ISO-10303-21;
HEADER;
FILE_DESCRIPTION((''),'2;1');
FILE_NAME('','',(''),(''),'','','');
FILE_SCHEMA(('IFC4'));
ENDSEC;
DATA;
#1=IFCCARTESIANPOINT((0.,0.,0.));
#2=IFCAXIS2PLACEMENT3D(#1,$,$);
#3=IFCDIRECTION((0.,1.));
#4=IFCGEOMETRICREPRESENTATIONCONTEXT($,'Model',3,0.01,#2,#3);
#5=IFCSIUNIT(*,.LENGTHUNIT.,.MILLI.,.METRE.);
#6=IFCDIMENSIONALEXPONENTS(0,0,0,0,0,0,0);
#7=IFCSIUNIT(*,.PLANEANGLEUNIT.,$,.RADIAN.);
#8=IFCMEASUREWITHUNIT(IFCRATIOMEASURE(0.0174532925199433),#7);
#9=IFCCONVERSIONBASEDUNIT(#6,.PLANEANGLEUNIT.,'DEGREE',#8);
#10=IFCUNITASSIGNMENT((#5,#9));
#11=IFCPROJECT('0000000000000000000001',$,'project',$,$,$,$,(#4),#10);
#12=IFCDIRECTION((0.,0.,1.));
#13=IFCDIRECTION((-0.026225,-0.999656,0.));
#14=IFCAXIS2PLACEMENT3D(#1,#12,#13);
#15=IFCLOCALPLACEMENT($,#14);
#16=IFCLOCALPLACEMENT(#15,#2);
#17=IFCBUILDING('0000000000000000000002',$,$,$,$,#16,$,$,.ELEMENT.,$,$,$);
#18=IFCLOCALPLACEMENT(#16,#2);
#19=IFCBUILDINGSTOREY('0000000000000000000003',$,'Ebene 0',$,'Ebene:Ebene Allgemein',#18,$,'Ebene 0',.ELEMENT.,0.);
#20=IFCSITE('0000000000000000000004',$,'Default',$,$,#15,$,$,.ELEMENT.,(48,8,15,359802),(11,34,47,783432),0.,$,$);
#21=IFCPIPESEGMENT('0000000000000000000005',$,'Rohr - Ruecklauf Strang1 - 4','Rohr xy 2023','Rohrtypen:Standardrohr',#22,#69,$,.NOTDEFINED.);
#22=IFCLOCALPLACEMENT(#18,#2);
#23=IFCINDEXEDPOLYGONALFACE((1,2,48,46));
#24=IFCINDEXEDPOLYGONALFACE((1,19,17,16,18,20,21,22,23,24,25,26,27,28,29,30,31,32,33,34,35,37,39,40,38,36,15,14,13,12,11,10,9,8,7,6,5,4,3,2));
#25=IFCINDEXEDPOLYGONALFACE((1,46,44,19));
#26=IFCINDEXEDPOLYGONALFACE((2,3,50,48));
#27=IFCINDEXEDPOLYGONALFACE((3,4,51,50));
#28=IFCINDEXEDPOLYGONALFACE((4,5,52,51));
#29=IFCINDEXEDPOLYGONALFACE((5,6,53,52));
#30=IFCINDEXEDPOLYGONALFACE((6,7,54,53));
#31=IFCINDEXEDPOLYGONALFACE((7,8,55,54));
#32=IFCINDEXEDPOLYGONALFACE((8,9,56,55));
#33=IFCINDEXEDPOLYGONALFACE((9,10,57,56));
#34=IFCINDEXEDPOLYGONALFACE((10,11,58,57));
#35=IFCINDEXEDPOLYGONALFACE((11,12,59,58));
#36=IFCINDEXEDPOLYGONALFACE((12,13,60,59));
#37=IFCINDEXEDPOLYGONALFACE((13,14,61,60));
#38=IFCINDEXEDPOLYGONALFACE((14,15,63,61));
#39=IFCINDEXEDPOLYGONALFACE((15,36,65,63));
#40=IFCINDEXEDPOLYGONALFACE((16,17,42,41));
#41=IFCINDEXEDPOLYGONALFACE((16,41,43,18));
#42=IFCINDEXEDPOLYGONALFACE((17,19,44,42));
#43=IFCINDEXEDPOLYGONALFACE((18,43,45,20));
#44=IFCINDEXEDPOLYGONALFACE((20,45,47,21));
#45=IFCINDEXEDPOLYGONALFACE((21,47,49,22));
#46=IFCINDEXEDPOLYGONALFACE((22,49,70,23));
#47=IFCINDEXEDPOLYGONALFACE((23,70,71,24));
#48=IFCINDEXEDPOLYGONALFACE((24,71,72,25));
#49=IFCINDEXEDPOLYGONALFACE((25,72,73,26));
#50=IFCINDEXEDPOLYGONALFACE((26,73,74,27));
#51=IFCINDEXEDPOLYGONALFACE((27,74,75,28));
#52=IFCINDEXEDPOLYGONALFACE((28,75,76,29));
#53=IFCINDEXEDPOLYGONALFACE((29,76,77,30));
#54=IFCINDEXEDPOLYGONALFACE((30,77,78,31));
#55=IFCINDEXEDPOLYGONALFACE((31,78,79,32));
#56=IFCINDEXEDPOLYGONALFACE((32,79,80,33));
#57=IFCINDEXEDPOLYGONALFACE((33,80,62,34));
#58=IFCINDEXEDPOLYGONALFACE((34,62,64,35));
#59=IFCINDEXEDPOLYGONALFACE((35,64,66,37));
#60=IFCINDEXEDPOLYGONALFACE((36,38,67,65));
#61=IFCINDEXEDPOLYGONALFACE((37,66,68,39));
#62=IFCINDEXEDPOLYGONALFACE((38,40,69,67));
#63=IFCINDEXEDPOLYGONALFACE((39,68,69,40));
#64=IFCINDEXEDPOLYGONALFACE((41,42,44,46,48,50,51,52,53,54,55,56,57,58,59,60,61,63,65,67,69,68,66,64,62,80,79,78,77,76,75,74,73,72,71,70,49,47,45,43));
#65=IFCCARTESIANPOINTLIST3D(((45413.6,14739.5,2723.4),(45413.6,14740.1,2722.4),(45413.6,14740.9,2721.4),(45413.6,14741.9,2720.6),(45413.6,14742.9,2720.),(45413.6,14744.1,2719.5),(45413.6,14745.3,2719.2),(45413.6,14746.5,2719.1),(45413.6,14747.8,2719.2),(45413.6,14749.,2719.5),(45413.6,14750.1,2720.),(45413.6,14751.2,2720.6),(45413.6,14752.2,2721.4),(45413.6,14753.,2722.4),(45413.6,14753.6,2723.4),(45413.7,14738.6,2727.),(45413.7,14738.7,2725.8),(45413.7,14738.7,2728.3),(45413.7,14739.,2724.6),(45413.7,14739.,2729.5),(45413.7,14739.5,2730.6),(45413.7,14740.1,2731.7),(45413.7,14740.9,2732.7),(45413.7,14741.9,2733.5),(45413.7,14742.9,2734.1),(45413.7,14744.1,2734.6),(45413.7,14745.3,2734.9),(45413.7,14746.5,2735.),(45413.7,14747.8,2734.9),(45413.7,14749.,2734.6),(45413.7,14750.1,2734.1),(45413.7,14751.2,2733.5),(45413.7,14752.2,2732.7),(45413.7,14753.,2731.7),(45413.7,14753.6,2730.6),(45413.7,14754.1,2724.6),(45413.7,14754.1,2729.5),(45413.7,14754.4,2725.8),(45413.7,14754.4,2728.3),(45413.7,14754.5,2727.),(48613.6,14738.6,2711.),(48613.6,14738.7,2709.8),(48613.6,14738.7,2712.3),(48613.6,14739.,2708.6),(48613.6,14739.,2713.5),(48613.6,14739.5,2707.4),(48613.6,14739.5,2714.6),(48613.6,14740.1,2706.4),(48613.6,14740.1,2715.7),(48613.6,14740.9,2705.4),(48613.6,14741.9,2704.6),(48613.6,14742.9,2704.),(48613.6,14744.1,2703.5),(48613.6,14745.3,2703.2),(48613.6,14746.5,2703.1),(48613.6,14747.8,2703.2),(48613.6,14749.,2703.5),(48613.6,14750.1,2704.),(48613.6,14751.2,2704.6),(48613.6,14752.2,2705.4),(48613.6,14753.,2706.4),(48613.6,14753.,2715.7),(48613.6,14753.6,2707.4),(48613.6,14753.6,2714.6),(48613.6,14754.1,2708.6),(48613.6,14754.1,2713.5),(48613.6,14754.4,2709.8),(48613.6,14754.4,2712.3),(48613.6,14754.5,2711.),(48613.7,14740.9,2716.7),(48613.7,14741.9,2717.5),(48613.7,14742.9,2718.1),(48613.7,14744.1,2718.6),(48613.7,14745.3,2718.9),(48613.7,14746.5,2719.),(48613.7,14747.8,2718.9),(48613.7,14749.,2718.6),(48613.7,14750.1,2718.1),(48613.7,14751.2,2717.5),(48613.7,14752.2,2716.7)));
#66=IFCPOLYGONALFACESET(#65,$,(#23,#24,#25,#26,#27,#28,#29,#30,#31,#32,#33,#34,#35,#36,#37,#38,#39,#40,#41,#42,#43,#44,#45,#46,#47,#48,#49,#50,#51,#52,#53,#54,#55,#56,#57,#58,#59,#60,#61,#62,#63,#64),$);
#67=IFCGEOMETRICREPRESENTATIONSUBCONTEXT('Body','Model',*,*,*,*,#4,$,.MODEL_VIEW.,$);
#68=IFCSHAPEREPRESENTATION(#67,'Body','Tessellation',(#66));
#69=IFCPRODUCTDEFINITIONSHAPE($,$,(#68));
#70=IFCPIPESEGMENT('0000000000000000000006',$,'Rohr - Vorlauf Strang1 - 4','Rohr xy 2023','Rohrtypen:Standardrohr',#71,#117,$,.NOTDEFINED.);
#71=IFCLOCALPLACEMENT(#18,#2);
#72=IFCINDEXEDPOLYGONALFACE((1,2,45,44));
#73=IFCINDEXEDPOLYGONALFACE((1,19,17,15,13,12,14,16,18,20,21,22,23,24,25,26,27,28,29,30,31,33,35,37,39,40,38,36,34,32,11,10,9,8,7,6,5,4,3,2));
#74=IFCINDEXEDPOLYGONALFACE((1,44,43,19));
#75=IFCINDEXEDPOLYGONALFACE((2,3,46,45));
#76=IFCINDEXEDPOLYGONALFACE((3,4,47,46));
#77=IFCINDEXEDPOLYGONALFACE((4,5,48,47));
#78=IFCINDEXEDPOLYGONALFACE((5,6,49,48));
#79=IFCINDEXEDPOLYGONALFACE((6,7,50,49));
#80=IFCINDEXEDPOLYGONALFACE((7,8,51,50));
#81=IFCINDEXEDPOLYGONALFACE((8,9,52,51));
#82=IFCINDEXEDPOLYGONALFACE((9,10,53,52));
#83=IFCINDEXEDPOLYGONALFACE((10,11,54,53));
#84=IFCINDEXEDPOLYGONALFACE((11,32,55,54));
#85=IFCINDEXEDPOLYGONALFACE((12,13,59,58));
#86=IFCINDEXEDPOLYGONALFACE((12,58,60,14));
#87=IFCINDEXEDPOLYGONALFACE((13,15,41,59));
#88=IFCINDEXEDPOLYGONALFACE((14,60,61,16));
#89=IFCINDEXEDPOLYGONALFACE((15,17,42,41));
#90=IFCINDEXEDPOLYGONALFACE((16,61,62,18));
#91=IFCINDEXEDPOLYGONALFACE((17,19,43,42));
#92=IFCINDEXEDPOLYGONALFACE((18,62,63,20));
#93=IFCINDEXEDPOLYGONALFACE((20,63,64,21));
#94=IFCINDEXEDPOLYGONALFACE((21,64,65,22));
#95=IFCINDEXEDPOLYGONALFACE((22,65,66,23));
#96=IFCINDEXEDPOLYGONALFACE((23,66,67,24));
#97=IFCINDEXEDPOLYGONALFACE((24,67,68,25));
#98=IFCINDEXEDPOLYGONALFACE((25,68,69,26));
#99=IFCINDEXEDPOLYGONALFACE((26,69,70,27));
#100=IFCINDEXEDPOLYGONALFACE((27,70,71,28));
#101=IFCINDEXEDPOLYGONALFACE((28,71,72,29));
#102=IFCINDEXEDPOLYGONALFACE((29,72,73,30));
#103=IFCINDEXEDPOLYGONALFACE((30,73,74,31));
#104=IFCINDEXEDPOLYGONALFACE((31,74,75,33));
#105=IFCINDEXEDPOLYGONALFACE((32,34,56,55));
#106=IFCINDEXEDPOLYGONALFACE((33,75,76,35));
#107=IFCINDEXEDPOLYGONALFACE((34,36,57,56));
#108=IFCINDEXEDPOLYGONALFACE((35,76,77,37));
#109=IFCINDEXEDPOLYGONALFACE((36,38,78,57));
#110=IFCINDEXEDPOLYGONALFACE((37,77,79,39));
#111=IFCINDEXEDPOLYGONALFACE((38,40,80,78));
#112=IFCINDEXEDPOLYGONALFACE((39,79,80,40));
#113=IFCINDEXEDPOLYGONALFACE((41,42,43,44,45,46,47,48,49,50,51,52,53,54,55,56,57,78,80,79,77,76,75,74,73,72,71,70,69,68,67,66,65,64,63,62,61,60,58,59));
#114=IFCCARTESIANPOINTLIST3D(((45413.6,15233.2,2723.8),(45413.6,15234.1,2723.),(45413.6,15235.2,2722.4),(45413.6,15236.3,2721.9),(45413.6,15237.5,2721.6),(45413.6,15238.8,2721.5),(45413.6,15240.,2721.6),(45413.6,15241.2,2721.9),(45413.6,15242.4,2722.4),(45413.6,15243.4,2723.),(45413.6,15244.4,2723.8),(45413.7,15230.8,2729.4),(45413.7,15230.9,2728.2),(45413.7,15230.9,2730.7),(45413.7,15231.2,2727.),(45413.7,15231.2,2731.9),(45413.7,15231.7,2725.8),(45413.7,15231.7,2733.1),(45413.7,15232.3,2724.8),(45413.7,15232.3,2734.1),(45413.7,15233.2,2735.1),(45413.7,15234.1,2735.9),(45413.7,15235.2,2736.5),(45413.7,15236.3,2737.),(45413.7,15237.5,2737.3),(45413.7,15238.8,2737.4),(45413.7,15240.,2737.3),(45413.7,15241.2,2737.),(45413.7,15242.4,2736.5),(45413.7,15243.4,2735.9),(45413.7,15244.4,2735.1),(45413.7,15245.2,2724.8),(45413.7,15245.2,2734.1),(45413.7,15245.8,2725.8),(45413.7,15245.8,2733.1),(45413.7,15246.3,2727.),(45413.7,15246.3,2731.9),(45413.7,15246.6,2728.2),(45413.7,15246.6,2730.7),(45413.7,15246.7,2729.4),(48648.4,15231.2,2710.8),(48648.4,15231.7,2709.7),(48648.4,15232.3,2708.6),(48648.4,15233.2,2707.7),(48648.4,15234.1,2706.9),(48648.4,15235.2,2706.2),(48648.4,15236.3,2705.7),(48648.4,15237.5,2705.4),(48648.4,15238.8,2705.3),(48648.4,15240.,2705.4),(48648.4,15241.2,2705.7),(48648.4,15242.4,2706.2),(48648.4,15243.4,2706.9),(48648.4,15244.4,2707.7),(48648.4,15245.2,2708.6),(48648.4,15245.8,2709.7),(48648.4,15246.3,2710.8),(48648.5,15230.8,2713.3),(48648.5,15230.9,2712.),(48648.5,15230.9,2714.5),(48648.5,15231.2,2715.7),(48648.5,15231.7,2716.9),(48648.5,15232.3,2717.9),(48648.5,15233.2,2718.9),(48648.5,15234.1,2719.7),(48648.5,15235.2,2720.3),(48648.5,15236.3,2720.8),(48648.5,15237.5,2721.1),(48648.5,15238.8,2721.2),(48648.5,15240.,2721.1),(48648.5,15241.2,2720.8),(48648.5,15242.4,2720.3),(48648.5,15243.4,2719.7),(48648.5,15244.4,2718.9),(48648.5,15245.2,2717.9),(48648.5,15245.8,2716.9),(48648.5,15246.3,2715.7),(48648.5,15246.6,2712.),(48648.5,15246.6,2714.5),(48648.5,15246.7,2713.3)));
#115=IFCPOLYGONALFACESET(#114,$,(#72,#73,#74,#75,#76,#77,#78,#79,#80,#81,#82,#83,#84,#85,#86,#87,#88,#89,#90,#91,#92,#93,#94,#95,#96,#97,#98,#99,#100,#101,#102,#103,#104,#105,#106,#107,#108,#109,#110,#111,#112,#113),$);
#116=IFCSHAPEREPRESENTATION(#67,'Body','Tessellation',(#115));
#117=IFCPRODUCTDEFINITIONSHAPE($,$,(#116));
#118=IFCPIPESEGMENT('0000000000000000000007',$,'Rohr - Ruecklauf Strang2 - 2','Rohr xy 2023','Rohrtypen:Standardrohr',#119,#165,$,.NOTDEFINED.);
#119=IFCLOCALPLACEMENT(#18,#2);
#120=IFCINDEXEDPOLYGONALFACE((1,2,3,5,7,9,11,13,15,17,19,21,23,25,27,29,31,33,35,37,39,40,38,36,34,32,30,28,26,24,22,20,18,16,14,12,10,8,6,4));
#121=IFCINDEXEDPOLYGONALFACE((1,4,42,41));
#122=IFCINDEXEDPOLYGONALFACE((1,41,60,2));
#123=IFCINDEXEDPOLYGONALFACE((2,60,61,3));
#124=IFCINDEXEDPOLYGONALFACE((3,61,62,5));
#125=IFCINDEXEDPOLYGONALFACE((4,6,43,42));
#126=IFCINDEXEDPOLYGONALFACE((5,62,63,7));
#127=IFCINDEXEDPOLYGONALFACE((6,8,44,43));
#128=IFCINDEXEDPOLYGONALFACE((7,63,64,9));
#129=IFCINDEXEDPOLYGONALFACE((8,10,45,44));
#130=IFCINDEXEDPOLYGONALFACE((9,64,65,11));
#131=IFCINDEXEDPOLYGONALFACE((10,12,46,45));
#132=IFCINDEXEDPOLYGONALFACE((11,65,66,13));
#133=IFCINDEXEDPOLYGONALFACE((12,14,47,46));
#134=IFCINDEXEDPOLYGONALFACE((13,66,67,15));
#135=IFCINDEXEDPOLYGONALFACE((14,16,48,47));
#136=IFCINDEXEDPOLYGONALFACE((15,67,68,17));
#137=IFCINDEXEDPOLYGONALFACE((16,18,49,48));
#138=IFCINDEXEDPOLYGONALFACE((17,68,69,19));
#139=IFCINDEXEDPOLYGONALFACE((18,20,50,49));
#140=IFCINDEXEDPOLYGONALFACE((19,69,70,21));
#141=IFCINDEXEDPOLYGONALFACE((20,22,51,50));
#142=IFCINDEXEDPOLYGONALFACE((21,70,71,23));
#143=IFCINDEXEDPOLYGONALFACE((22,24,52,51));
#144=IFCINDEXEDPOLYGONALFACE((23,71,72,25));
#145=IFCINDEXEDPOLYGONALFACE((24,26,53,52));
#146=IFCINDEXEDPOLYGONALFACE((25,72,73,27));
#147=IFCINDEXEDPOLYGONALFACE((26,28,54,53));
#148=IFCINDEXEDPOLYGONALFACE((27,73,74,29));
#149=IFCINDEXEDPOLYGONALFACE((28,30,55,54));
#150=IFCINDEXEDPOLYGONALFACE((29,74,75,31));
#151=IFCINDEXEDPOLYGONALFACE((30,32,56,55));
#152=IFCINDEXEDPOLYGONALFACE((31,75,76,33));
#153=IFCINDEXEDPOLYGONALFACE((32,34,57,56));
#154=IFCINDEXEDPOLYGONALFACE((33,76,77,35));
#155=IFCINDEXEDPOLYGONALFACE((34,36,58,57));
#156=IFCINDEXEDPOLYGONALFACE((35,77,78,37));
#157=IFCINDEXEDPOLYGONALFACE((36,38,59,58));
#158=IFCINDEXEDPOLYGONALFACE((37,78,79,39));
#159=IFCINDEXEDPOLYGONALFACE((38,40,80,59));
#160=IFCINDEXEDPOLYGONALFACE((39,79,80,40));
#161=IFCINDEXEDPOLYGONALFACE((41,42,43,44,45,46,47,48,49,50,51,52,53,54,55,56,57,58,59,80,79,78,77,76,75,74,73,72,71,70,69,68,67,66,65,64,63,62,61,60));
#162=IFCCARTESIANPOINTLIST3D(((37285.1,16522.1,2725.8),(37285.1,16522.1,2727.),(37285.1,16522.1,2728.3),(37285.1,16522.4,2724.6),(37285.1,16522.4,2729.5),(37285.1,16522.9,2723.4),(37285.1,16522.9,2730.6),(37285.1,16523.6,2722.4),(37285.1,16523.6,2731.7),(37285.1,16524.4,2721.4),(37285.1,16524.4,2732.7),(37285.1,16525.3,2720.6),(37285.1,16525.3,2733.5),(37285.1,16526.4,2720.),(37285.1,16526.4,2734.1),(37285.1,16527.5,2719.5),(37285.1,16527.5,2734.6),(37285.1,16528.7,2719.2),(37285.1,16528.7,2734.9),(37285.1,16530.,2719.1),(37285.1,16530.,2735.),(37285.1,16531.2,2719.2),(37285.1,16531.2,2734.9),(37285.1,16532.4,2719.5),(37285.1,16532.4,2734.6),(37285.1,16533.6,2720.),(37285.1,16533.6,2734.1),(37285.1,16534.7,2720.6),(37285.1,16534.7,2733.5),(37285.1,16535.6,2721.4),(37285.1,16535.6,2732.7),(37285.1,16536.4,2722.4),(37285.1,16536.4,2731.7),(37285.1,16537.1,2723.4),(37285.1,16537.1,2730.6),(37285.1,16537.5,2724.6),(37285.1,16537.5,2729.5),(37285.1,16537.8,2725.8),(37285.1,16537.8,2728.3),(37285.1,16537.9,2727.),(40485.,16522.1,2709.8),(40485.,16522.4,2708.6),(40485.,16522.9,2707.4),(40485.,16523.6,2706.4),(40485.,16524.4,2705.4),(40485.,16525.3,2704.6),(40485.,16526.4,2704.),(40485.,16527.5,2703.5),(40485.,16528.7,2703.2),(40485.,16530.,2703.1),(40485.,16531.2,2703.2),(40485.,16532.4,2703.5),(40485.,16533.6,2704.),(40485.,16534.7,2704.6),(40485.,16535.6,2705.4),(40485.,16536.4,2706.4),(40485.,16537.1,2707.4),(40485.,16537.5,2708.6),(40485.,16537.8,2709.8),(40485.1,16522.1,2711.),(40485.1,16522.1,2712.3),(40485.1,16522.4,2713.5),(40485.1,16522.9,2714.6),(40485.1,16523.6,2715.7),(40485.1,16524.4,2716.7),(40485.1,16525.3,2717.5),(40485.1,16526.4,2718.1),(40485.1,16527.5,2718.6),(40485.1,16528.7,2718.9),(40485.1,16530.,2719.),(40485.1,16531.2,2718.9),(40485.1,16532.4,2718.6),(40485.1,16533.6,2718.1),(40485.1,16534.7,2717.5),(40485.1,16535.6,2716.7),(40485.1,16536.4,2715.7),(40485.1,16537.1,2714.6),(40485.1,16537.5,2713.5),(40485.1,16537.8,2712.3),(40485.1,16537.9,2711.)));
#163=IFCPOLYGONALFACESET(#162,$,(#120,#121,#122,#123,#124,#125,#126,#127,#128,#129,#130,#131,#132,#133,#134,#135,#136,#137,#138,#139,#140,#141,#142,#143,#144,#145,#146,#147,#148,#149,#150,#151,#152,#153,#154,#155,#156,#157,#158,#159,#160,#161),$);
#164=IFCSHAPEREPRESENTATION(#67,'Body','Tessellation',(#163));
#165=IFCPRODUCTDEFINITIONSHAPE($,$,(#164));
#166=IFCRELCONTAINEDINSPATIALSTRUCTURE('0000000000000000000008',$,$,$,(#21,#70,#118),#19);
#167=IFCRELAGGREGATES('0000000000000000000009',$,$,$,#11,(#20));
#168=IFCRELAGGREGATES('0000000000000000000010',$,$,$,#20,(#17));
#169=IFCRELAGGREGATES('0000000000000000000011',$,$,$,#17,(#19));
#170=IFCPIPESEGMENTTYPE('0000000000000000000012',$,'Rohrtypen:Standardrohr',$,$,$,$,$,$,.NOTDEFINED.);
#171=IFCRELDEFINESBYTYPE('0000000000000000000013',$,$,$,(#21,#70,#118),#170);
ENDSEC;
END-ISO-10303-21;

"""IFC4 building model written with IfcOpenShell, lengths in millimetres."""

from ifc_helpers import new_model, entity, si_unit, converted_unit, direction, frame, origin, place, context, subcontext, project, spatial, indexed_curve, outline, extrude, type_object, element, save


model = new_model("IFC4")

# Units and contexts
model_context = context("Model", 3, precision=0.01, world=origin(), true_north=direction((0.0, 1.0)))
body_context = subcontext(model_context, "Body", "Model", "MODEL_VIEW")
ifc_project = project(units=[si_unit("LENGTHUNIT", "METRE", prefix="MILLI"), converted_unit("PLANEANGLEUNIT", "DEGREE", entity("IfcRatioMeasure", 0.0174532925199433), si_unit("PLANEANGLEUNIT", "RADIAN"), dimensions=[0, 0, 0, 0, 0, 0, 0])], contexts=[model_context])

# Site, building, storey
site_placement = place(None, frame((0.0, 0.0, 0.0), z_axis=(0.0, 0.0, 1.0), x_axis=(-0.026225, -0.999656, 0.0)))
site = spatial("IfcSite", under=ifc_project, at=site_placement, Name="Default", CompositionType="ELEMENT", RefLatitude=(48, 8, 15, 359802), RefLongitude=(11, 34, 47, 783432), RefElevation=0.0)
building_placement = place(site_placement, origin())
building = spatial("IfcBuilding", under=site, at=building_placement, CompositionType="ELEMENT")
storey_placement = place(building_placement, origin())
storey = spatial("IfcBuildingStorey", under=building, at=storey_placement, Name="Ebene 0", ObjectType="Ebene:Ebene Allgemein", LongName="Ebene 0", CompositionType="ELEMENT", Elevation=0.0)

# Pipe segments
pipe_segment_type = type_object("IfcPipeSegmentType", Name="Rohrtypen:Standardrohr", PredefinedType="NOTDEFINED")
pipe_segment_1_placement = place(storey_placement, origin())
element("IfcPipeSegment", 1, at=pipe_segment_1_placement, inside=storey, type_object=pipe_segment_type, Name="Rohr - Ruecklauf Strang1 - 4", Description="Rohr xy 2023", ObjectType="Rohrtypen:Standardrohr", PredefinedType="NOTDEFINED", context=body_context, shape_type="SweptSolid", body=[
    extrude(outline(indexed_curve([(7.9, 0.0), (7.8, 1.2), (7.6, 2.5), (7.1, 3.6), (6.4, 4.7), (5.6, 5.6), (4.7, 6.4), (3.6, 7.1), (2.5, 7.6), (1.2, 7.8), (0.0, 7.9), (-1.2, 7.8), (-2.5, 7.6), (-3.6, 7.1), (-4.7, 6.4), (-5.6, 5.6), (-6.4, 4.7), (-7.1, 3.6), (-7.6, 2.5), (-7.8, 1.2), (-7.9, 0.0), (-7.8, -1.2), (-7.6, -2.5), (-7.1, -3.6), (-6.4, -4.7), (-5.6, -5.6), (-4.7, -6.4), (-3.6, -7.1), (-2.5, -7.6), (-1.2, -7.8), (0.0, -7.9), (1.2, -7.8), (2.5, -7.6), (3.6, -7.1), (4.7, -6.4), (5.6, -5.6), (6.4, -4.7), (7.1, -3.6), (7.6, -2.5), (7.8, -1.2), (7.9, 0.0)], self_intersect=False)), frame((48613.6, 14746.5, 2711.0), z_axis=(-0.999988, 0.0, 0.005), x_axis=(0.0, 1.0, 0.0)), (0.0, 0.0, 1.0), 3200.0),
])
pipe_segment_2_placement = place(storey_placement, origin())
element("IfcPipeSegment", 2, at=pipe_segment_2_placement, inside=storey, type_object=pipe_segment_type, Name="Rohr - Vorlauf Strang1 - 4", Description="Rohr xy 2023", ObjectType="Rohrtypen:Standardrohr", PredefinedType="NOTDEFINED", context=body_context, shape_type="SweptSolid", body=[
    extrude(outline(indexed_curve([(7.9, 0.0), (7.8, 1.2), (7.6, 2.5), (7.1, 3.6), (6.4, 4.7), (5.6, 5.6), (4.7, 6.4), (3.6, 7.1), (2.5, 7.6), (1.2, 7.8), (0.0, 7.9), (-1.2, 7.8), (-2.5, 7.6), (-3.6, 7.1), (-4.7, 6.4), (-5.6, 5.6), (-6.4, 4.7), (-7.1, 3.6), (-7.6, 2.5), (-7.8, 1.2), (-7.9, 0.0), (-7.8, -1.2), (-7.6, -2.5), (-7.1, -3.6), (-6.4, -4.7), (-5.6, -5.6), (-4.7, -6.4), (-3.6, -7.1), (-2.5, -7.6), (-1.2, -7.8), (0.0, -7.9), (1.2, -7.8), (2.5, -7.6), (3.6, -7.1), (4.7, -6.4), (5.6, -5.6), (6.4, -4.7), (7.1, -3.6), (7.6, -2.5), (7.8, -1.2), (7.9, 0.0)], self_intersect=False)), frame((48648.5, 15238.8, 2713.3), z_axis=(-0.999988, 0.0, 0.005), x_axis=(0.0, 1.0, 0.0)), (0.0, 0.0, 1.0), 3234.8),
])
pipe_segment_3_placement = place(storey_placement, origin())
element("IfcPipeSegment", 3, at=pipe_segment_3_placement, inside=storey, type_object=pipe_segment_type, Name="Rohr - Ruecklauf Strang2 - 2", Description="Rohr xy 2023", ObjectType="Rohrtypen:Standardrohr", PredefinedType="NOTDEFINED", context=body_context, shape_type="SweptSolid", body=[
    extrude(outline(indexed_curve([(7.9, 0.0), (7.8, 1.2), (7.6, 2.5), (7.1, 3.6), (6.4, 4.7), (5.6, 5.6), (4.7, 6.4), (3.6, 7.1), (2.5, 7.6), (1.2, 7.8), (0.0, 7.9), (-1.2, 7.8), (-2.5, 7.6), (-3.6, 7.1), (-4.7, 6.4), (-5.6, 5.6), (-6.4, 4.7), (-7.1, 3.6), (-7.6, 2.5), (-7.8, 1.2), (-7.9, 0.0), (-7.8, -1.2), (-7.6, -2.5), (-7.1, -3.6), (-6.4, -4.7), (-5.6, -5.6), (-4.7, -6.4), (-3.6, -7.1), (-2.5, -7.6), (-1.2, -7.8), (0.0, -7.9), (1.2, -7.8), (2.5, -7.6), (3.6, -7.1), (4.7, -6.4), (5.6, -5.6), (6.4, -4.7), (7.1, -3.6), (7.6, -2.5), (7.8, -1.2), (7.9, 0.0)], self_intersect=False)), frame((40485.1, 16530.0, 2711.0), z_axis=(-0.999988, 0.0, 0.005), x_axis=(0.0, 1.0, 0.0)), (0.0, 0.0, 1.0), 3200.0),
])

save(model, "model.ifc")
